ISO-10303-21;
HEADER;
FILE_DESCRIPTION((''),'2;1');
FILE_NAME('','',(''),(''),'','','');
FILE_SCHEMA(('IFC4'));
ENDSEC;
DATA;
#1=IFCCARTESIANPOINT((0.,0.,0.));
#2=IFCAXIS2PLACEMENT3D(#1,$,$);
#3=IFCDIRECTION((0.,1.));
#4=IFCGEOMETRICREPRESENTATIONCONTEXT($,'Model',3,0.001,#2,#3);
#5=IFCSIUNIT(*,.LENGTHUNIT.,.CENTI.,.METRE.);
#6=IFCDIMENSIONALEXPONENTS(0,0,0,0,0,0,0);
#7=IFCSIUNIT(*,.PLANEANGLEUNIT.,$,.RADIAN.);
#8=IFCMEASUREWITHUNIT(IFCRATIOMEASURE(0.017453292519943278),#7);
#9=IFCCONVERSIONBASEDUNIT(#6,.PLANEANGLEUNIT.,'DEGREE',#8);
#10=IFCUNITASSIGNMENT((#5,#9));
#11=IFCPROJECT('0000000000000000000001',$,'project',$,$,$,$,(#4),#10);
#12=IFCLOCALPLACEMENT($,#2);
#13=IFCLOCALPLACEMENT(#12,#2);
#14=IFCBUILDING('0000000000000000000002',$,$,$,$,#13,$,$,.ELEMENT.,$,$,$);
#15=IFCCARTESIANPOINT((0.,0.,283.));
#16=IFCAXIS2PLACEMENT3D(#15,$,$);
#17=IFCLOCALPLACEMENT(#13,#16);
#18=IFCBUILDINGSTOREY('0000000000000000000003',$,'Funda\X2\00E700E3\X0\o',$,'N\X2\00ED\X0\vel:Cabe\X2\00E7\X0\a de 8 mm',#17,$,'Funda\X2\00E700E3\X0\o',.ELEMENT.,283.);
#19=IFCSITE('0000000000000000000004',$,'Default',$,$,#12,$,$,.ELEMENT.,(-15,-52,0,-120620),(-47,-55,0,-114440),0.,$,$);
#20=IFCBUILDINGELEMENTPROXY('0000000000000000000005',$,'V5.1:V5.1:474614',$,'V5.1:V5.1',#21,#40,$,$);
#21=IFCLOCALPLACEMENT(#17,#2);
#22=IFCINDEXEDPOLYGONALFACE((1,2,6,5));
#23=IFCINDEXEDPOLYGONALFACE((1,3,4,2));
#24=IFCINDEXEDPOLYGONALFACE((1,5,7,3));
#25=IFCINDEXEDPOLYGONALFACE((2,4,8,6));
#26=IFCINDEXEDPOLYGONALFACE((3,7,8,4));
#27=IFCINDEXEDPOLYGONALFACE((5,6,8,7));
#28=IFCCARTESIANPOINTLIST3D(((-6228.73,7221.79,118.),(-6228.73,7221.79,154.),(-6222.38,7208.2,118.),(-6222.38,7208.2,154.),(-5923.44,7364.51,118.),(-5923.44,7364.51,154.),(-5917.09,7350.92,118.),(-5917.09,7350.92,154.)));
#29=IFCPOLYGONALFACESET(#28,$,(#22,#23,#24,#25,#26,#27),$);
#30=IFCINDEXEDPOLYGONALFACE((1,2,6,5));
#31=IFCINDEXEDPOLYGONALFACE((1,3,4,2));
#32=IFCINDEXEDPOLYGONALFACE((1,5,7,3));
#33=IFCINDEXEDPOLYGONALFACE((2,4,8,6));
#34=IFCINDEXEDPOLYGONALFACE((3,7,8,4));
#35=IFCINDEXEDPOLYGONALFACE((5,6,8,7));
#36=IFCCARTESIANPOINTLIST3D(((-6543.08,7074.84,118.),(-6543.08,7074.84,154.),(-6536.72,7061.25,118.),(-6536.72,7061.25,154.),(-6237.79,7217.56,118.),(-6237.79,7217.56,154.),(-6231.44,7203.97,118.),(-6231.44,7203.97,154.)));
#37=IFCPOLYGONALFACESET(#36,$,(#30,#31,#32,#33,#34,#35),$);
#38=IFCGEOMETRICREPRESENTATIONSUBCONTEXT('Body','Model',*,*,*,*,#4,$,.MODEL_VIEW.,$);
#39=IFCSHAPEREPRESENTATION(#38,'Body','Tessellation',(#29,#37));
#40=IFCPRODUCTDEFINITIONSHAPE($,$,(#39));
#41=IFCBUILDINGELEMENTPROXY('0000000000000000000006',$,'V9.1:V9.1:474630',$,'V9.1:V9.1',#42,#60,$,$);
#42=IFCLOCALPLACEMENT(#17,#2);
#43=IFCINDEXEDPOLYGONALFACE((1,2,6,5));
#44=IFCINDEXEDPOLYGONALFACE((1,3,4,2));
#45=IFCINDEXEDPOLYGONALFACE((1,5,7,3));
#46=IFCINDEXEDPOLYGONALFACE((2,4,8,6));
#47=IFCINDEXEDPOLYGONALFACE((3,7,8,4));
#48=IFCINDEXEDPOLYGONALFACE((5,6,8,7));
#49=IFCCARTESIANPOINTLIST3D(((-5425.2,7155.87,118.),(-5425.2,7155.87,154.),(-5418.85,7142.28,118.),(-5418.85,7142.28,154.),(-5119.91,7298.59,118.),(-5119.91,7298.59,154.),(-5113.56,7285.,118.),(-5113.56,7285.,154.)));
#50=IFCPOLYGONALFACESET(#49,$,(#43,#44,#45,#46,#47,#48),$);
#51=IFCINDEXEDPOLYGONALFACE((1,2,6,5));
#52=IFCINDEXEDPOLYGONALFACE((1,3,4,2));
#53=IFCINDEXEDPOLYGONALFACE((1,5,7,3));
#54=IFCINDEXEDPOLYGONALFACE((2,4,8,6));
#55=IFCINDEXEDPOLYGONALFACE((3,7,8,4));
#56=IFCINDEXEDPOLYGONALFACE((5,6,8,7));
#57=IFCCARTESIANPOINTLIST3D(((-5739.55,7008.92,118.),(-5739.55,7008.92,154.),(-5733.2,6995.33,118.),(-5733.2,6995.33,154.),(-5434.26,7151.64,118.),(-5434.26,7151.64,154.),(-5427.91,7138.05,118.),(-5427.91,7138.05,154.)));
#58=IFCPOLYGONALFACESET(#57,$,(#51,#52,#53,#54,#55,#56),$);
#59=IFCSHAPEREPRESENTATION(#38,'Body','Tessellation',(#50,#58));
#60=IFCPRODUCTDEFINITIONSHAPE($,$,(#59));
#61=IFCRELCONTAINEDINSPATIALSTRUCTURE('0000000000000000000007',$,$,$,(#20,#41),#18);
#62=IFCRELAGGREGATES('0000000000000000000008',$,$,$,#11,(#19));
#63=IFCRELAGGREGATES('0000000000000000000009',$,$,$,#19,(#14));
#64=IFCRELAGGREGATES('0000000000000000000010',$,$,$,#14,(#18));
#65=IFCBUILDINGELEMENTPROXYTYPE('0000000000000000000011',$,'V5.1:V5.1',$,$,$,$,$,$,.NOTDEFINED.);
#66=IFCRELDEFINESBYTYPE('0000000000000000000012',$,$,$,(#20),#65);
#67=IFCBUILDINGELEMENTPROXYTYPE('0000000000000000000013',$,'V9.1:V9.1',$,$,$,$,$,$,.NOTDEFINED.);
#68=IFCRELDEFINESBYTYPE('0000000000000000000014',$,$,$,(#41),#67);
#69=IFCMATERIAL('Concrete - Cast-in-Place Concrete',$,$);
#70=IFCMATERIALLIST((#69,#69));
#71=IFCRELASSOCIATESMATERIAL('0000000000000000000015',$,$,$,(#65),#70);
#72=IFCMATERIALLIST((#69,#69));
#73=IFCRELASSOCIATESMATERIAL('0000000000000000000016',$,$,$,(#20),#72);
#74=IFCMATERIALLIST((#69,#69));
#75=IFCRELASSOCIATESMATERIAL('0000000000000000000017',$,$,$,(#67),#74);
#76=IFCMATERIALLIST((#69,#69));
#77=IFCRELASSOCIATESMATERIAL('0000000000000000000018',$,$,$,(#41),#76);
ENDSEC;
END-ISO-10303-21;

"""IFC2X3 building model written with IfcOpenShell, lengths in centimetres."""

from ifc_helpers import new_model, entity, si_unit, converted_unit, direction, frame, frame_2d, origin, origin_2d_with_axis, place, context, subcontext, project, spatial, rectangle, extrude, source, transform, mapped, material, material_list, type_object, type_shapes, element, save


model = new_model("IFC2X3")

# Units and contexts
model_context = context("Model", 3, precision=0.001, world=origin(), true_north=direction((0.0, 1.0)))
body_context = subcontext(model_context, "Body", "Model", "MODEL_VIEW")
ifc_project = project(units=[si_unit("LENGTHUNIT", "METRE", prefix="CENTI"), converted_unit("PLANEANGLEUNIT", "DEGREE", entity("IfcRatioMeasure", 0.017453292519943278), si_unit("PLANEANGLEUNIT", "RADIAN"), dimensions=[0, 0, 0, 0, 0, 0, 0])], contexts=[model_context])

# Site, building, storey
site_placement = place(None, origin())
site = spatial("IfcSite", under=ifc_project, at=site_placement, Name="Default", CompositionType="ELEMENT", RefLatitude=(-15, -52, 0, -120620), RefLongitude=(-47, -55, 0, -114440), RefElevation=0.0)
building_placement = place(site_placement, origin())
building = spatial("IfcBuilding", under=site, at=building_placement, CompositionType="ELEMENT")
storey_placement = place(building_placement, frame((0.0, 0.0, 283.0)))
storey = spatial("IfcBuildingStorey", under=building, at=storey_placement, Name="Fundação", ObjectType="Nível:Cabeça de 8 mm", LongName="Fundação", CompositionType="ELEMENT", Elevation=283.0)

# Building element proxies
ifc_material_1 = material(Name="Concrete - Cast-in-Place Concrete")
ifc_material_list_1 = material_list([ifc_material_1, ifc_material_1])
ifc_material_list_2 = material_list([ifc_material_1, ifc_material_1])
building_element_proxy_type_1 = type_object("IfcBuildingElementProxyType", Name="V5.1:V5.1", PredefinedType="NOTDEFINED", material=ifc_material_list_2)
shared_shape_1 = source(origin(), body_context, "Body", "SweptSolid", [
    extrude(rectangle(XDim=15.0, YDim=337.0, at=origin_2d_with_axis()), frame((470.17, 225.1, 0.0), z_axis=(0.0, 0.0, 1.0), x_axis=(-0.423488, 0.905902, 0.0)), (0.0, 0.0, 1.0), 36.0),
    extrude(rectangle(XDim=337.0, YDim=15.0, at=frame_2d((0.0, 0.0), x_axis=(1.0, 0.0))), frame((155.82, 78.15, 0.0), z_axis=(0.0, 0.0, 1.0), x_axis=(-0.905902, -0.423488, 0.0)), (0.0, 0.0, 1.0), 36.0),
])
type_shapes(building_element_proxy_type_1, [shared_shape_1])
proxy_1_placement = place(storey_placement, frame((-6543.08, 7061.25, 118.0)))
element("IfcBuildingElementProxy", 1, at=proxy_1_placement, inside=storey, type_object=building_element_proxy_type_1, material=ifc_material_list_1, Name="V5.1:V5.1:474614", ObjectType="V5.1:V5.1", context=body_context, shape_type="MappedRepresentation", body=[
    mapped(shared_shape_1, transform((0.0, 0.0, 0.0), scale=1.0)),
])
ifc_material_list_3 = material_list([ifc_material_1, ifc_material_1])
ifc_material_list_4 = material_list([ifc_material_1, ifc_material_1])
building_element_proxy_type_2 = type_object("IfcBuildingElementProxyType", Name="V9.1:V9.1", PredefinedType="NOTDEFINED", material=ifc_material_list_4)
shared_shape_2 = source(origin(), body_context, "Body", "SweptSolid", [
    extrude(rectangle(XDim=15.0, YDim=337.0, at=frame_2d((0.0, 0.0), x_axis=(1.0, 0.0))), frame((470.17, 225.1, 0.0), z_axis=(0.0, 0.0, 1.0), x_axis=(-0.423488, 0.905902, 0.0)), (0.0, 0.0, 1.0), 36.0),
    extrude(rectangle(XDim=337.0, YDim=15.0, at=frame_2d((0.0, 0.0), x_axis=(1.0, 0.0))), frame((155.82, 78.15, 0.0), z_axis=(0.0, 0.0, 1.0), x_axis=(-0.905902, -0.423488, 0.0)), (0.0, 0.0, 1.0), 36.0),
])
type_shapes(building_element_proxy_type_2, [shared_shape_2])
proxy_2_placement = place(storey_placement, frame((-5739.55, 6995.33, 118.0)))
element("IfcBuildingElementProxy", 2, at=proxy_2_placement, inside=storey, type_object=building_element_proxy_type_2, material=ifc_material_list_3, Name="V9.1:V9.1:474630", ObjectType="V9.1:V9.1", context=body_context, shape_type="MappedRepresentation", body=[
    mapped(shared_shape_2, transform((0.0, 0.0, 0.0), scale=1.0)),
])

save(model, "model.ifc")
